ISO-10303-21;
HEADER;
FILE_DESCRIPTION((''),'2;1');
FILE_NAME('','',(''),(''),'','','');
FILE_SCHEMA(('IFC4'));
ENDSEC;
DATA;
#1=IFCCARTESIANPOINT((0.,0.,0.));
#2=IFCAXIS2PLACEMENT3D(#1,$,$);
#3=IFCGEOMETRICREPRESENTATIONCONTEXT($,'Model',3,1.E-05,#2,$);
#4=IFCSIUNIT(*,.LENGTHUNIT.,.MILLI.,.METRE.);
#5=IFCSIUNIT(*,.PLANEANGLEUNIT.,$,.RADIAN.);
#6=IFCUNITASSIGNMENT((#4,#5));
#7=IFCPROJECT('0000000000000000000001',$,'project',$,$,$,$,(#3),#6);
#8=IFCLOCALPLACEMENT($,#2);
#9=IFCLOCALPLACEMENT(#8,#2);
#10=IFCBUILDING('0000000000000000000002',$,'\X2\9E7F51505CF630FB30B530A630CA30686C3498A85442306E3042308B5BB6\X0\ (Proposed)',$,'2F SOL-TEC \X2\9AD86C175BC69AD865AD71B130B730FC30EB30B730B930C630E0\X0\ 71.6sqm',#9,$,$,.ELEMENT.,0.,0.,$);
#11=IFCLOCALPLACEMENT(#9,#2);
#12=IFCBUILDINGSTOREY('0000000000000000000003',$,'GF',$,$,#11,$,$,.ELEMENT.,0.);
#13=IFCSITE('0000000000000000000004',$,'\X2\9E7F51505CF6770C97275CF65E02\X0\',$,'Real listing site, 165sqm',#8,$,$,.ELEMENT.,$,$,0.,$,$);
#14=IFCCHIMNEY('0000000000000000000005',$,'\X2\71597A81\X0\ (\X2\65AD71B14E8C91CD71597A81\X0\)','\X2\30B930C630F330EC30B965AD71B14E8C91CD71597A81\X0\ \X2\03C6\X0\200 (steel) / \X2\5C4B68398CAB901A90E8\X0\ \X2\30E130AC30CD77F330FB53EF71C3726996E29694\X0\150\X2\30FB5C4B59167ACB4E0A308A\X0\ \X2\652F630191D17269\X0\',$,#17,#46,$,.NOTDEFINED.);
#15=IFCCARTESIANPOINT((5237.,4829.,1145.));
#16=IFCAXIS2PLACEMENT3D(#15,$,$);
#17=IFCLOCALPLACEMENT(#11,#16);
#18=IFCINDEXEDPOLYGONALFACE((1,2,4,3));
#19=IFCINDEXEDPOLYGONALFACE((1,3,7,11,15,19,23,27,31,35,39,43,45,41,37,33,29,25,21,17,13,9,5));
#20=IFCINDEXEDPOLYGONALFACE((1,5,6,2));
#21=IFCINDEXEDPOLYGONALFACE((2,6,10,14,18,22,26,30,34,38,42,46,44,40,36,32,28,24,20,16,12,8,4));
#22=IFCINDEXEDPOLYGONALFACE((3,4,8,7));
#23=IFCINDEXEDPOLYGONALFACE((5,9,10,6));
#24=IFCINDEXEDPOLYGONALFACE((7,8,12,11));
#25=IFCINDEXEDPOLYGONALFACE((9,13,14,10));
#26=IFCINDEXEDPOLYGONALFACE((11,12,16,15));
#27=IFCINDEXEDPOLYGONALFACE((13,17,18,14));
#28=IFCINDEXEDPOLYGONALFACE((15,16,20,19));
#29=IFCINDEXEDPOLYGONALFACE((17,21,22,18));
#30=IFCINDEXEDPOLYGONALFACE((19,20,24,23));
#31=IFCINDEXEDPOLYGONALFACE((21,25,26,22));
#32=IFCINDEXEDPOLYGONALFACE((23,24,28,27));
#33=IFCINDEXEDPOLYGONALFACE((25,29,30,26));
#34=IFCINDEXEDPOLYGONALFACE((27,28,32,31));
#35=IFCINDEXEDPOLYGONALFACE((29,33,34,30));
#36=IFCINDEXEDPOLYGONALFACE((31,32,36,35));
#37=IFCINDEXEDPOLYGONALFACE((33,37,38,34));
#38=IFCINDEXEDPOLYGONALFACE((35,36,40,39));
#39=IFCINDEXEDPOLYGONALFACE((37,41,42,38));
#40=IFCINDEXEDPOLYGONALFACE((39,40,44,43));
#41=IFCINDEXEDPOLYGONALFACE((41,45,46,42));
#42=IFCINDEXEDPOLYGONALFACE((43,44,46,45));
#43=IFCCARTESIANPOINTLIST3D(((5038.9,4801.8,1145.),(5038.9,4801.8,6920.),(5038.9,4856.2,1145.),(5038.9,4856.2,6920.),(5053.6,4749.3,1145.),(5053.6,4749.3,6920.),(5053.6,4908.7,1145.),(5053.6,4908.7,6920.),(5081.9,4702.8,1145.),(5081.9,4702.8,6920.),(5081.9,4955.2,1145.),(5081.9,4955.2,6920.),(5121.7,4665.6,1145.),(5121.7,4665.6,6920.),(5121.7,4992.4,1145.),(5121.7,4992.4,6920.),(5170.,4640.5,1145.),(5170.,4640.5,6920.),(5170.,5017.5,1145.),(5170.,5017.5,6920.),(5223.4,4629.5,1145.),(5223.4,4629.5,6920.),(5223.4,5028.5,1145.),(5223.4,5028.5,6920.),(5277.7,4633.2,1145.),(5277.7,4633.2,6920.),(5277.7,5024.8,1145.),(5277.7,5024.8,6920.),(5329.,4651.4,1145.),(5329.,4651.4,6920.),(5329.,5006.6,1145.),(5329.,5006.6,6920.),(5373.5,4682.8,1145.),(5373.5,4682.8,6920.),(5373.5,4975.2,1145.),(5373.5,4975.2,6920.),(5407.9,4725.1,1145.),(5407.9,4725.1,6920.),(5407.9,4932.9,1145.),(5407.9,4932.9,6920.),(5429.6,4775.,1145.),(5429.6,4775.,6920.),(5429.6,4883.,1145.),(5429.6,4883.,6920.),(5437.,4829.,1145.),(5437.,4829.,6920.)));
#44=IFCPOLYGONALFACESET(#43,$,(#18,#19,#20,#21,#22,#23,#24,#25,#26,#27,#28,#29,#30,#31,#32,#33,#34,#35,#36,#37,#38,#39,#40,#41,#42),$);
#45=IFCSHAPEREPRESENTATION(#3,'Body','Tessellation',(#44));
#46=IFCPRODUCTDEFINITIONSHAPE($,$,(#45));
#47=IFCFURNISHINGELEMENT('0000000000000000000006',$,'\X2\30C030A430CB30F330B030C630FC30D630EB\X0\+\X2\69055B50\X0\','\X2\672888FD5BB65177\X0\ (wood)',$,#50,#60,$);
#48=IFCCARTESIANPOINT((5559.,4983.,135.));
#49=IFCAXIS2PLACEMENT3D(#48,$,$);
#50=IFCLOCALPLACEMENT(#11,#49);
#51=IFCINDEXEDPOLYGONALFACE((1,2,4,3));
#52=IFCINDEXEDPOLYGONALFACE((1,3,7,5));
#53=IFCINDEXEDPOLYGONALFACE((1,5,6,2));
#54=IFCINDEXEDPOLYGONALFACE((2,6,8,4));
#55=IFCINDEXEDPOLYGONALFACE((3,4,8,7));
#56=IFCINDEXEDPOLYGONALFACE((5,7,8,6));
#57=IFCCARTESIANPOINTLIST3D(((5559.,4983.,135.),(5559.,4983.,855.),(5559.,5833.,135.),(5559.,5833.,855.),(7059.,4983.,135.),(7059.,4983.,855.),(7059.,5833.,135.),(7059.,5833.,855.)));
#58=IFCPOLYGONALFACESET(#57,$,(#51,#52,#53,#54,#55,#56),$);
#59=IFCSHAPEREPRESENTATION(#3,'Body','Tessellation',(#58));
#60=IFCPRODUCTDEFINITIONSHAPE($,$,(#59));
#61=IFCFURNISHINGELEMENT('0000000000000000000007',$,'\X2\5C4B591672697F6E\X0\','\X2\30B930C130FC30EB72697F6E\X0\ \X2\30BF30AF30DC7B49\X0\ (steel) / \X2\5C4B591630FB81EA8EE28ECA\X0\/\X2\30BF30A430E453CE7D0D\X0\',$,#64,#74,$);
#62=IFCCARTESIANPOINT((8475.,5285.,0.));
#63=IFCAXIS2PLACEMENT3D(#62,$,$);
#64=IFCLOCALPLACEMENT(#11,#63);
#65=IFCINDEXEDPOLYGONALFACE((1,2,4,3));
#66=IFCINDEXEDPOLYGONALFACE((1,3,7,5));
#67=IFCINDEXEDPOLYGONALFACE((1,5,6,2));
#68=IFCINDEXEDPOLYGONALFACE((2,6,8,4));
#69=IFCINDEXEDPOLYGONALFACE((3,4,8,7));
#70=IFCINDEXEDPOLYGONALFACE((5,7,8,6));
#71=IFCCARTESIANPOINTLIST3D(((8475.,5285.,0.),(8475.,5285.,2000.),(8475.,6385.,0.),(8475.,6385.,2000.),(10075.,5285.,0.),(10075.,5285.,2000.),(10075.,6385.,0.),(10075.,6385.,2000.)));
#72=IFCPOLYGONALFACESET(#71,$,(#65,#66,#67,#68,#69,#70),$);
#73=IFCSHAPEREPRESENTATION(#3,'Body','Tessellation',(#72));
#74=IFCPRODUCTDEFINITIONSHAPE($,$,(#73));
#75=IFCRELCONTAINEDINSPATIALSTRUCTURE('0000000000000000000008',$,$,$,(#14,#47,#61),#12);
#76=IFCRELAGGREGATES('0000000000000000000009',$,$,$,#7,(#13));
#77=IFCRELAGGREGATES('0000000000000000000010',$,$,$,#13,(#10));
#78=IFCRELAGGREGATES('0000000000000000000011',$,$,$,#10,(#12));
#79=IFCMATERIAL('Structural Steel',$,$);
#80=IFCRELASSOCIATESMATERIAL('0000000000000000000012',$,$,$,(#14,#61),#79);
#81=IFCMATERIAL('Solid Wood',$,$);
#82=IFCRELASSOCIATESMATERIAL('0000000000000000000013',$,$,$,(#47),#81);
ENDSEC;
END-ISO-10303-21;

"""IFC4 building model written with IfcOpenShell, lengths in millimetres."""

from ifc_helpers import new_model, si_unit, frame, frame_2d, origin, origin_2d, place, context, project, spatial, rectangle, circle, extrude, material, element, save


model = new_model("IFC4")

# Units and contexts
model_context = context("Model", 3, precision=1e-05, world=origin())
ifc_project = project(units=[si_unit("LENGTHUNIT", "METRE", prefix="MILLI"), si_unit("PLANEANGLEUNIT", "RADIAN")], contexts=[model_context])

# Site, building, storey
site_placement = place(None, origin())
site = spatial("IfcSite", under=ifc_project, at=site_placement, Name="鹿児島県霧島市", ObjectType="Real listing site, 165sqm", CompositionType="ELEMENT", RefElevation=0.0)
building_placement = place(site_placement, origin())
building = spatial("IfcBuilding", under=site, at=building_placement, Name="鹿児島・サウナと水風呂のある家 (Proposed)", ObjectType="2F SOL-TEC 高気密高断熱シールシステム 71.6sqm", CompositionType="ELEMENT", ElevationOfRefHeight=0.0, ElevationOfTerrain=0.0)
storey_placement = place(building_placement, origin())
storey = spatial("IfcBuildingStorey", under=building, at=storey_placement, Name="GF", CompositionType="ELEMENT", Elevation=0.0)

# Shared definitions
ifc_material_1 = material(Name="Solid Wood")

# Shared definitions
ifc_material_2 = material(Name="Structural Steel")

# Chimney
chimney_placement = place(storey_placement, frame((5237.0, 4829.0, 1145.0)))
element("IfcChimney", 1, at=chimney_placement, inside=storey, material=ifc_material_2, Name="煙突 (断熱二重煙突)", Description="ステンレス断熱二重煙突 φ200 (steel) / 屋根貫通部 メガネ石・可燃物離隔150・屋外立上り 支持金物", PredefinedType="NOTDEFINED", context=model_context, shape_type="SweptSolid", body=[
    extrude(circle(Radius=200.0, at=origin_2d()), frame((5237.0, 4829.0, 1145.0)), (0.0, 0.0, 1.0), 5775.0),
])

# Furnishing elements
furnishing_1_placement = place(storey_placement, frame((5559.0, 4983.0, 135.0)))
element("IfcFurnishingElement", 2, at=furnishing_1_placement, inside=storey, material=ifc_material_1, Name="ダイニングテーブル+椅子", Description="木製家具 (wood)", context=model_context, shape_type="SweptSolid", body=[
    extrude(rectangle(XDim=1500.0, YDim=850.0, at=frame_2d((750.0, 425.0))), frame((5559.0, 4983.0, 135.0)), (0.0, 0.0, 1.0), 720.0),
])
furnishing_2_placement = place(storey_placement, frame((8475.0, 5285.0, 0.0)))
element("IfcFurnishingElement", 3, at=furnishing_2_placement, inside=storey, material=ifc_material_2, Name="屋外物置", Description="スチール物置 タクボ等 (steel) / 屋外・自転車/タイヤ収納", context=model_context, shape_type="SweptSolid", body=[
    extrude(rectangle(XDim=1600.0, YDim=1100.0, at=frame_2d((800.0, 550.0))), frame((8475.0, 5285.0, 0.0)), (0.0, 0.0, 1.0), 2000.0),
])

save(model, "model.ifc")
